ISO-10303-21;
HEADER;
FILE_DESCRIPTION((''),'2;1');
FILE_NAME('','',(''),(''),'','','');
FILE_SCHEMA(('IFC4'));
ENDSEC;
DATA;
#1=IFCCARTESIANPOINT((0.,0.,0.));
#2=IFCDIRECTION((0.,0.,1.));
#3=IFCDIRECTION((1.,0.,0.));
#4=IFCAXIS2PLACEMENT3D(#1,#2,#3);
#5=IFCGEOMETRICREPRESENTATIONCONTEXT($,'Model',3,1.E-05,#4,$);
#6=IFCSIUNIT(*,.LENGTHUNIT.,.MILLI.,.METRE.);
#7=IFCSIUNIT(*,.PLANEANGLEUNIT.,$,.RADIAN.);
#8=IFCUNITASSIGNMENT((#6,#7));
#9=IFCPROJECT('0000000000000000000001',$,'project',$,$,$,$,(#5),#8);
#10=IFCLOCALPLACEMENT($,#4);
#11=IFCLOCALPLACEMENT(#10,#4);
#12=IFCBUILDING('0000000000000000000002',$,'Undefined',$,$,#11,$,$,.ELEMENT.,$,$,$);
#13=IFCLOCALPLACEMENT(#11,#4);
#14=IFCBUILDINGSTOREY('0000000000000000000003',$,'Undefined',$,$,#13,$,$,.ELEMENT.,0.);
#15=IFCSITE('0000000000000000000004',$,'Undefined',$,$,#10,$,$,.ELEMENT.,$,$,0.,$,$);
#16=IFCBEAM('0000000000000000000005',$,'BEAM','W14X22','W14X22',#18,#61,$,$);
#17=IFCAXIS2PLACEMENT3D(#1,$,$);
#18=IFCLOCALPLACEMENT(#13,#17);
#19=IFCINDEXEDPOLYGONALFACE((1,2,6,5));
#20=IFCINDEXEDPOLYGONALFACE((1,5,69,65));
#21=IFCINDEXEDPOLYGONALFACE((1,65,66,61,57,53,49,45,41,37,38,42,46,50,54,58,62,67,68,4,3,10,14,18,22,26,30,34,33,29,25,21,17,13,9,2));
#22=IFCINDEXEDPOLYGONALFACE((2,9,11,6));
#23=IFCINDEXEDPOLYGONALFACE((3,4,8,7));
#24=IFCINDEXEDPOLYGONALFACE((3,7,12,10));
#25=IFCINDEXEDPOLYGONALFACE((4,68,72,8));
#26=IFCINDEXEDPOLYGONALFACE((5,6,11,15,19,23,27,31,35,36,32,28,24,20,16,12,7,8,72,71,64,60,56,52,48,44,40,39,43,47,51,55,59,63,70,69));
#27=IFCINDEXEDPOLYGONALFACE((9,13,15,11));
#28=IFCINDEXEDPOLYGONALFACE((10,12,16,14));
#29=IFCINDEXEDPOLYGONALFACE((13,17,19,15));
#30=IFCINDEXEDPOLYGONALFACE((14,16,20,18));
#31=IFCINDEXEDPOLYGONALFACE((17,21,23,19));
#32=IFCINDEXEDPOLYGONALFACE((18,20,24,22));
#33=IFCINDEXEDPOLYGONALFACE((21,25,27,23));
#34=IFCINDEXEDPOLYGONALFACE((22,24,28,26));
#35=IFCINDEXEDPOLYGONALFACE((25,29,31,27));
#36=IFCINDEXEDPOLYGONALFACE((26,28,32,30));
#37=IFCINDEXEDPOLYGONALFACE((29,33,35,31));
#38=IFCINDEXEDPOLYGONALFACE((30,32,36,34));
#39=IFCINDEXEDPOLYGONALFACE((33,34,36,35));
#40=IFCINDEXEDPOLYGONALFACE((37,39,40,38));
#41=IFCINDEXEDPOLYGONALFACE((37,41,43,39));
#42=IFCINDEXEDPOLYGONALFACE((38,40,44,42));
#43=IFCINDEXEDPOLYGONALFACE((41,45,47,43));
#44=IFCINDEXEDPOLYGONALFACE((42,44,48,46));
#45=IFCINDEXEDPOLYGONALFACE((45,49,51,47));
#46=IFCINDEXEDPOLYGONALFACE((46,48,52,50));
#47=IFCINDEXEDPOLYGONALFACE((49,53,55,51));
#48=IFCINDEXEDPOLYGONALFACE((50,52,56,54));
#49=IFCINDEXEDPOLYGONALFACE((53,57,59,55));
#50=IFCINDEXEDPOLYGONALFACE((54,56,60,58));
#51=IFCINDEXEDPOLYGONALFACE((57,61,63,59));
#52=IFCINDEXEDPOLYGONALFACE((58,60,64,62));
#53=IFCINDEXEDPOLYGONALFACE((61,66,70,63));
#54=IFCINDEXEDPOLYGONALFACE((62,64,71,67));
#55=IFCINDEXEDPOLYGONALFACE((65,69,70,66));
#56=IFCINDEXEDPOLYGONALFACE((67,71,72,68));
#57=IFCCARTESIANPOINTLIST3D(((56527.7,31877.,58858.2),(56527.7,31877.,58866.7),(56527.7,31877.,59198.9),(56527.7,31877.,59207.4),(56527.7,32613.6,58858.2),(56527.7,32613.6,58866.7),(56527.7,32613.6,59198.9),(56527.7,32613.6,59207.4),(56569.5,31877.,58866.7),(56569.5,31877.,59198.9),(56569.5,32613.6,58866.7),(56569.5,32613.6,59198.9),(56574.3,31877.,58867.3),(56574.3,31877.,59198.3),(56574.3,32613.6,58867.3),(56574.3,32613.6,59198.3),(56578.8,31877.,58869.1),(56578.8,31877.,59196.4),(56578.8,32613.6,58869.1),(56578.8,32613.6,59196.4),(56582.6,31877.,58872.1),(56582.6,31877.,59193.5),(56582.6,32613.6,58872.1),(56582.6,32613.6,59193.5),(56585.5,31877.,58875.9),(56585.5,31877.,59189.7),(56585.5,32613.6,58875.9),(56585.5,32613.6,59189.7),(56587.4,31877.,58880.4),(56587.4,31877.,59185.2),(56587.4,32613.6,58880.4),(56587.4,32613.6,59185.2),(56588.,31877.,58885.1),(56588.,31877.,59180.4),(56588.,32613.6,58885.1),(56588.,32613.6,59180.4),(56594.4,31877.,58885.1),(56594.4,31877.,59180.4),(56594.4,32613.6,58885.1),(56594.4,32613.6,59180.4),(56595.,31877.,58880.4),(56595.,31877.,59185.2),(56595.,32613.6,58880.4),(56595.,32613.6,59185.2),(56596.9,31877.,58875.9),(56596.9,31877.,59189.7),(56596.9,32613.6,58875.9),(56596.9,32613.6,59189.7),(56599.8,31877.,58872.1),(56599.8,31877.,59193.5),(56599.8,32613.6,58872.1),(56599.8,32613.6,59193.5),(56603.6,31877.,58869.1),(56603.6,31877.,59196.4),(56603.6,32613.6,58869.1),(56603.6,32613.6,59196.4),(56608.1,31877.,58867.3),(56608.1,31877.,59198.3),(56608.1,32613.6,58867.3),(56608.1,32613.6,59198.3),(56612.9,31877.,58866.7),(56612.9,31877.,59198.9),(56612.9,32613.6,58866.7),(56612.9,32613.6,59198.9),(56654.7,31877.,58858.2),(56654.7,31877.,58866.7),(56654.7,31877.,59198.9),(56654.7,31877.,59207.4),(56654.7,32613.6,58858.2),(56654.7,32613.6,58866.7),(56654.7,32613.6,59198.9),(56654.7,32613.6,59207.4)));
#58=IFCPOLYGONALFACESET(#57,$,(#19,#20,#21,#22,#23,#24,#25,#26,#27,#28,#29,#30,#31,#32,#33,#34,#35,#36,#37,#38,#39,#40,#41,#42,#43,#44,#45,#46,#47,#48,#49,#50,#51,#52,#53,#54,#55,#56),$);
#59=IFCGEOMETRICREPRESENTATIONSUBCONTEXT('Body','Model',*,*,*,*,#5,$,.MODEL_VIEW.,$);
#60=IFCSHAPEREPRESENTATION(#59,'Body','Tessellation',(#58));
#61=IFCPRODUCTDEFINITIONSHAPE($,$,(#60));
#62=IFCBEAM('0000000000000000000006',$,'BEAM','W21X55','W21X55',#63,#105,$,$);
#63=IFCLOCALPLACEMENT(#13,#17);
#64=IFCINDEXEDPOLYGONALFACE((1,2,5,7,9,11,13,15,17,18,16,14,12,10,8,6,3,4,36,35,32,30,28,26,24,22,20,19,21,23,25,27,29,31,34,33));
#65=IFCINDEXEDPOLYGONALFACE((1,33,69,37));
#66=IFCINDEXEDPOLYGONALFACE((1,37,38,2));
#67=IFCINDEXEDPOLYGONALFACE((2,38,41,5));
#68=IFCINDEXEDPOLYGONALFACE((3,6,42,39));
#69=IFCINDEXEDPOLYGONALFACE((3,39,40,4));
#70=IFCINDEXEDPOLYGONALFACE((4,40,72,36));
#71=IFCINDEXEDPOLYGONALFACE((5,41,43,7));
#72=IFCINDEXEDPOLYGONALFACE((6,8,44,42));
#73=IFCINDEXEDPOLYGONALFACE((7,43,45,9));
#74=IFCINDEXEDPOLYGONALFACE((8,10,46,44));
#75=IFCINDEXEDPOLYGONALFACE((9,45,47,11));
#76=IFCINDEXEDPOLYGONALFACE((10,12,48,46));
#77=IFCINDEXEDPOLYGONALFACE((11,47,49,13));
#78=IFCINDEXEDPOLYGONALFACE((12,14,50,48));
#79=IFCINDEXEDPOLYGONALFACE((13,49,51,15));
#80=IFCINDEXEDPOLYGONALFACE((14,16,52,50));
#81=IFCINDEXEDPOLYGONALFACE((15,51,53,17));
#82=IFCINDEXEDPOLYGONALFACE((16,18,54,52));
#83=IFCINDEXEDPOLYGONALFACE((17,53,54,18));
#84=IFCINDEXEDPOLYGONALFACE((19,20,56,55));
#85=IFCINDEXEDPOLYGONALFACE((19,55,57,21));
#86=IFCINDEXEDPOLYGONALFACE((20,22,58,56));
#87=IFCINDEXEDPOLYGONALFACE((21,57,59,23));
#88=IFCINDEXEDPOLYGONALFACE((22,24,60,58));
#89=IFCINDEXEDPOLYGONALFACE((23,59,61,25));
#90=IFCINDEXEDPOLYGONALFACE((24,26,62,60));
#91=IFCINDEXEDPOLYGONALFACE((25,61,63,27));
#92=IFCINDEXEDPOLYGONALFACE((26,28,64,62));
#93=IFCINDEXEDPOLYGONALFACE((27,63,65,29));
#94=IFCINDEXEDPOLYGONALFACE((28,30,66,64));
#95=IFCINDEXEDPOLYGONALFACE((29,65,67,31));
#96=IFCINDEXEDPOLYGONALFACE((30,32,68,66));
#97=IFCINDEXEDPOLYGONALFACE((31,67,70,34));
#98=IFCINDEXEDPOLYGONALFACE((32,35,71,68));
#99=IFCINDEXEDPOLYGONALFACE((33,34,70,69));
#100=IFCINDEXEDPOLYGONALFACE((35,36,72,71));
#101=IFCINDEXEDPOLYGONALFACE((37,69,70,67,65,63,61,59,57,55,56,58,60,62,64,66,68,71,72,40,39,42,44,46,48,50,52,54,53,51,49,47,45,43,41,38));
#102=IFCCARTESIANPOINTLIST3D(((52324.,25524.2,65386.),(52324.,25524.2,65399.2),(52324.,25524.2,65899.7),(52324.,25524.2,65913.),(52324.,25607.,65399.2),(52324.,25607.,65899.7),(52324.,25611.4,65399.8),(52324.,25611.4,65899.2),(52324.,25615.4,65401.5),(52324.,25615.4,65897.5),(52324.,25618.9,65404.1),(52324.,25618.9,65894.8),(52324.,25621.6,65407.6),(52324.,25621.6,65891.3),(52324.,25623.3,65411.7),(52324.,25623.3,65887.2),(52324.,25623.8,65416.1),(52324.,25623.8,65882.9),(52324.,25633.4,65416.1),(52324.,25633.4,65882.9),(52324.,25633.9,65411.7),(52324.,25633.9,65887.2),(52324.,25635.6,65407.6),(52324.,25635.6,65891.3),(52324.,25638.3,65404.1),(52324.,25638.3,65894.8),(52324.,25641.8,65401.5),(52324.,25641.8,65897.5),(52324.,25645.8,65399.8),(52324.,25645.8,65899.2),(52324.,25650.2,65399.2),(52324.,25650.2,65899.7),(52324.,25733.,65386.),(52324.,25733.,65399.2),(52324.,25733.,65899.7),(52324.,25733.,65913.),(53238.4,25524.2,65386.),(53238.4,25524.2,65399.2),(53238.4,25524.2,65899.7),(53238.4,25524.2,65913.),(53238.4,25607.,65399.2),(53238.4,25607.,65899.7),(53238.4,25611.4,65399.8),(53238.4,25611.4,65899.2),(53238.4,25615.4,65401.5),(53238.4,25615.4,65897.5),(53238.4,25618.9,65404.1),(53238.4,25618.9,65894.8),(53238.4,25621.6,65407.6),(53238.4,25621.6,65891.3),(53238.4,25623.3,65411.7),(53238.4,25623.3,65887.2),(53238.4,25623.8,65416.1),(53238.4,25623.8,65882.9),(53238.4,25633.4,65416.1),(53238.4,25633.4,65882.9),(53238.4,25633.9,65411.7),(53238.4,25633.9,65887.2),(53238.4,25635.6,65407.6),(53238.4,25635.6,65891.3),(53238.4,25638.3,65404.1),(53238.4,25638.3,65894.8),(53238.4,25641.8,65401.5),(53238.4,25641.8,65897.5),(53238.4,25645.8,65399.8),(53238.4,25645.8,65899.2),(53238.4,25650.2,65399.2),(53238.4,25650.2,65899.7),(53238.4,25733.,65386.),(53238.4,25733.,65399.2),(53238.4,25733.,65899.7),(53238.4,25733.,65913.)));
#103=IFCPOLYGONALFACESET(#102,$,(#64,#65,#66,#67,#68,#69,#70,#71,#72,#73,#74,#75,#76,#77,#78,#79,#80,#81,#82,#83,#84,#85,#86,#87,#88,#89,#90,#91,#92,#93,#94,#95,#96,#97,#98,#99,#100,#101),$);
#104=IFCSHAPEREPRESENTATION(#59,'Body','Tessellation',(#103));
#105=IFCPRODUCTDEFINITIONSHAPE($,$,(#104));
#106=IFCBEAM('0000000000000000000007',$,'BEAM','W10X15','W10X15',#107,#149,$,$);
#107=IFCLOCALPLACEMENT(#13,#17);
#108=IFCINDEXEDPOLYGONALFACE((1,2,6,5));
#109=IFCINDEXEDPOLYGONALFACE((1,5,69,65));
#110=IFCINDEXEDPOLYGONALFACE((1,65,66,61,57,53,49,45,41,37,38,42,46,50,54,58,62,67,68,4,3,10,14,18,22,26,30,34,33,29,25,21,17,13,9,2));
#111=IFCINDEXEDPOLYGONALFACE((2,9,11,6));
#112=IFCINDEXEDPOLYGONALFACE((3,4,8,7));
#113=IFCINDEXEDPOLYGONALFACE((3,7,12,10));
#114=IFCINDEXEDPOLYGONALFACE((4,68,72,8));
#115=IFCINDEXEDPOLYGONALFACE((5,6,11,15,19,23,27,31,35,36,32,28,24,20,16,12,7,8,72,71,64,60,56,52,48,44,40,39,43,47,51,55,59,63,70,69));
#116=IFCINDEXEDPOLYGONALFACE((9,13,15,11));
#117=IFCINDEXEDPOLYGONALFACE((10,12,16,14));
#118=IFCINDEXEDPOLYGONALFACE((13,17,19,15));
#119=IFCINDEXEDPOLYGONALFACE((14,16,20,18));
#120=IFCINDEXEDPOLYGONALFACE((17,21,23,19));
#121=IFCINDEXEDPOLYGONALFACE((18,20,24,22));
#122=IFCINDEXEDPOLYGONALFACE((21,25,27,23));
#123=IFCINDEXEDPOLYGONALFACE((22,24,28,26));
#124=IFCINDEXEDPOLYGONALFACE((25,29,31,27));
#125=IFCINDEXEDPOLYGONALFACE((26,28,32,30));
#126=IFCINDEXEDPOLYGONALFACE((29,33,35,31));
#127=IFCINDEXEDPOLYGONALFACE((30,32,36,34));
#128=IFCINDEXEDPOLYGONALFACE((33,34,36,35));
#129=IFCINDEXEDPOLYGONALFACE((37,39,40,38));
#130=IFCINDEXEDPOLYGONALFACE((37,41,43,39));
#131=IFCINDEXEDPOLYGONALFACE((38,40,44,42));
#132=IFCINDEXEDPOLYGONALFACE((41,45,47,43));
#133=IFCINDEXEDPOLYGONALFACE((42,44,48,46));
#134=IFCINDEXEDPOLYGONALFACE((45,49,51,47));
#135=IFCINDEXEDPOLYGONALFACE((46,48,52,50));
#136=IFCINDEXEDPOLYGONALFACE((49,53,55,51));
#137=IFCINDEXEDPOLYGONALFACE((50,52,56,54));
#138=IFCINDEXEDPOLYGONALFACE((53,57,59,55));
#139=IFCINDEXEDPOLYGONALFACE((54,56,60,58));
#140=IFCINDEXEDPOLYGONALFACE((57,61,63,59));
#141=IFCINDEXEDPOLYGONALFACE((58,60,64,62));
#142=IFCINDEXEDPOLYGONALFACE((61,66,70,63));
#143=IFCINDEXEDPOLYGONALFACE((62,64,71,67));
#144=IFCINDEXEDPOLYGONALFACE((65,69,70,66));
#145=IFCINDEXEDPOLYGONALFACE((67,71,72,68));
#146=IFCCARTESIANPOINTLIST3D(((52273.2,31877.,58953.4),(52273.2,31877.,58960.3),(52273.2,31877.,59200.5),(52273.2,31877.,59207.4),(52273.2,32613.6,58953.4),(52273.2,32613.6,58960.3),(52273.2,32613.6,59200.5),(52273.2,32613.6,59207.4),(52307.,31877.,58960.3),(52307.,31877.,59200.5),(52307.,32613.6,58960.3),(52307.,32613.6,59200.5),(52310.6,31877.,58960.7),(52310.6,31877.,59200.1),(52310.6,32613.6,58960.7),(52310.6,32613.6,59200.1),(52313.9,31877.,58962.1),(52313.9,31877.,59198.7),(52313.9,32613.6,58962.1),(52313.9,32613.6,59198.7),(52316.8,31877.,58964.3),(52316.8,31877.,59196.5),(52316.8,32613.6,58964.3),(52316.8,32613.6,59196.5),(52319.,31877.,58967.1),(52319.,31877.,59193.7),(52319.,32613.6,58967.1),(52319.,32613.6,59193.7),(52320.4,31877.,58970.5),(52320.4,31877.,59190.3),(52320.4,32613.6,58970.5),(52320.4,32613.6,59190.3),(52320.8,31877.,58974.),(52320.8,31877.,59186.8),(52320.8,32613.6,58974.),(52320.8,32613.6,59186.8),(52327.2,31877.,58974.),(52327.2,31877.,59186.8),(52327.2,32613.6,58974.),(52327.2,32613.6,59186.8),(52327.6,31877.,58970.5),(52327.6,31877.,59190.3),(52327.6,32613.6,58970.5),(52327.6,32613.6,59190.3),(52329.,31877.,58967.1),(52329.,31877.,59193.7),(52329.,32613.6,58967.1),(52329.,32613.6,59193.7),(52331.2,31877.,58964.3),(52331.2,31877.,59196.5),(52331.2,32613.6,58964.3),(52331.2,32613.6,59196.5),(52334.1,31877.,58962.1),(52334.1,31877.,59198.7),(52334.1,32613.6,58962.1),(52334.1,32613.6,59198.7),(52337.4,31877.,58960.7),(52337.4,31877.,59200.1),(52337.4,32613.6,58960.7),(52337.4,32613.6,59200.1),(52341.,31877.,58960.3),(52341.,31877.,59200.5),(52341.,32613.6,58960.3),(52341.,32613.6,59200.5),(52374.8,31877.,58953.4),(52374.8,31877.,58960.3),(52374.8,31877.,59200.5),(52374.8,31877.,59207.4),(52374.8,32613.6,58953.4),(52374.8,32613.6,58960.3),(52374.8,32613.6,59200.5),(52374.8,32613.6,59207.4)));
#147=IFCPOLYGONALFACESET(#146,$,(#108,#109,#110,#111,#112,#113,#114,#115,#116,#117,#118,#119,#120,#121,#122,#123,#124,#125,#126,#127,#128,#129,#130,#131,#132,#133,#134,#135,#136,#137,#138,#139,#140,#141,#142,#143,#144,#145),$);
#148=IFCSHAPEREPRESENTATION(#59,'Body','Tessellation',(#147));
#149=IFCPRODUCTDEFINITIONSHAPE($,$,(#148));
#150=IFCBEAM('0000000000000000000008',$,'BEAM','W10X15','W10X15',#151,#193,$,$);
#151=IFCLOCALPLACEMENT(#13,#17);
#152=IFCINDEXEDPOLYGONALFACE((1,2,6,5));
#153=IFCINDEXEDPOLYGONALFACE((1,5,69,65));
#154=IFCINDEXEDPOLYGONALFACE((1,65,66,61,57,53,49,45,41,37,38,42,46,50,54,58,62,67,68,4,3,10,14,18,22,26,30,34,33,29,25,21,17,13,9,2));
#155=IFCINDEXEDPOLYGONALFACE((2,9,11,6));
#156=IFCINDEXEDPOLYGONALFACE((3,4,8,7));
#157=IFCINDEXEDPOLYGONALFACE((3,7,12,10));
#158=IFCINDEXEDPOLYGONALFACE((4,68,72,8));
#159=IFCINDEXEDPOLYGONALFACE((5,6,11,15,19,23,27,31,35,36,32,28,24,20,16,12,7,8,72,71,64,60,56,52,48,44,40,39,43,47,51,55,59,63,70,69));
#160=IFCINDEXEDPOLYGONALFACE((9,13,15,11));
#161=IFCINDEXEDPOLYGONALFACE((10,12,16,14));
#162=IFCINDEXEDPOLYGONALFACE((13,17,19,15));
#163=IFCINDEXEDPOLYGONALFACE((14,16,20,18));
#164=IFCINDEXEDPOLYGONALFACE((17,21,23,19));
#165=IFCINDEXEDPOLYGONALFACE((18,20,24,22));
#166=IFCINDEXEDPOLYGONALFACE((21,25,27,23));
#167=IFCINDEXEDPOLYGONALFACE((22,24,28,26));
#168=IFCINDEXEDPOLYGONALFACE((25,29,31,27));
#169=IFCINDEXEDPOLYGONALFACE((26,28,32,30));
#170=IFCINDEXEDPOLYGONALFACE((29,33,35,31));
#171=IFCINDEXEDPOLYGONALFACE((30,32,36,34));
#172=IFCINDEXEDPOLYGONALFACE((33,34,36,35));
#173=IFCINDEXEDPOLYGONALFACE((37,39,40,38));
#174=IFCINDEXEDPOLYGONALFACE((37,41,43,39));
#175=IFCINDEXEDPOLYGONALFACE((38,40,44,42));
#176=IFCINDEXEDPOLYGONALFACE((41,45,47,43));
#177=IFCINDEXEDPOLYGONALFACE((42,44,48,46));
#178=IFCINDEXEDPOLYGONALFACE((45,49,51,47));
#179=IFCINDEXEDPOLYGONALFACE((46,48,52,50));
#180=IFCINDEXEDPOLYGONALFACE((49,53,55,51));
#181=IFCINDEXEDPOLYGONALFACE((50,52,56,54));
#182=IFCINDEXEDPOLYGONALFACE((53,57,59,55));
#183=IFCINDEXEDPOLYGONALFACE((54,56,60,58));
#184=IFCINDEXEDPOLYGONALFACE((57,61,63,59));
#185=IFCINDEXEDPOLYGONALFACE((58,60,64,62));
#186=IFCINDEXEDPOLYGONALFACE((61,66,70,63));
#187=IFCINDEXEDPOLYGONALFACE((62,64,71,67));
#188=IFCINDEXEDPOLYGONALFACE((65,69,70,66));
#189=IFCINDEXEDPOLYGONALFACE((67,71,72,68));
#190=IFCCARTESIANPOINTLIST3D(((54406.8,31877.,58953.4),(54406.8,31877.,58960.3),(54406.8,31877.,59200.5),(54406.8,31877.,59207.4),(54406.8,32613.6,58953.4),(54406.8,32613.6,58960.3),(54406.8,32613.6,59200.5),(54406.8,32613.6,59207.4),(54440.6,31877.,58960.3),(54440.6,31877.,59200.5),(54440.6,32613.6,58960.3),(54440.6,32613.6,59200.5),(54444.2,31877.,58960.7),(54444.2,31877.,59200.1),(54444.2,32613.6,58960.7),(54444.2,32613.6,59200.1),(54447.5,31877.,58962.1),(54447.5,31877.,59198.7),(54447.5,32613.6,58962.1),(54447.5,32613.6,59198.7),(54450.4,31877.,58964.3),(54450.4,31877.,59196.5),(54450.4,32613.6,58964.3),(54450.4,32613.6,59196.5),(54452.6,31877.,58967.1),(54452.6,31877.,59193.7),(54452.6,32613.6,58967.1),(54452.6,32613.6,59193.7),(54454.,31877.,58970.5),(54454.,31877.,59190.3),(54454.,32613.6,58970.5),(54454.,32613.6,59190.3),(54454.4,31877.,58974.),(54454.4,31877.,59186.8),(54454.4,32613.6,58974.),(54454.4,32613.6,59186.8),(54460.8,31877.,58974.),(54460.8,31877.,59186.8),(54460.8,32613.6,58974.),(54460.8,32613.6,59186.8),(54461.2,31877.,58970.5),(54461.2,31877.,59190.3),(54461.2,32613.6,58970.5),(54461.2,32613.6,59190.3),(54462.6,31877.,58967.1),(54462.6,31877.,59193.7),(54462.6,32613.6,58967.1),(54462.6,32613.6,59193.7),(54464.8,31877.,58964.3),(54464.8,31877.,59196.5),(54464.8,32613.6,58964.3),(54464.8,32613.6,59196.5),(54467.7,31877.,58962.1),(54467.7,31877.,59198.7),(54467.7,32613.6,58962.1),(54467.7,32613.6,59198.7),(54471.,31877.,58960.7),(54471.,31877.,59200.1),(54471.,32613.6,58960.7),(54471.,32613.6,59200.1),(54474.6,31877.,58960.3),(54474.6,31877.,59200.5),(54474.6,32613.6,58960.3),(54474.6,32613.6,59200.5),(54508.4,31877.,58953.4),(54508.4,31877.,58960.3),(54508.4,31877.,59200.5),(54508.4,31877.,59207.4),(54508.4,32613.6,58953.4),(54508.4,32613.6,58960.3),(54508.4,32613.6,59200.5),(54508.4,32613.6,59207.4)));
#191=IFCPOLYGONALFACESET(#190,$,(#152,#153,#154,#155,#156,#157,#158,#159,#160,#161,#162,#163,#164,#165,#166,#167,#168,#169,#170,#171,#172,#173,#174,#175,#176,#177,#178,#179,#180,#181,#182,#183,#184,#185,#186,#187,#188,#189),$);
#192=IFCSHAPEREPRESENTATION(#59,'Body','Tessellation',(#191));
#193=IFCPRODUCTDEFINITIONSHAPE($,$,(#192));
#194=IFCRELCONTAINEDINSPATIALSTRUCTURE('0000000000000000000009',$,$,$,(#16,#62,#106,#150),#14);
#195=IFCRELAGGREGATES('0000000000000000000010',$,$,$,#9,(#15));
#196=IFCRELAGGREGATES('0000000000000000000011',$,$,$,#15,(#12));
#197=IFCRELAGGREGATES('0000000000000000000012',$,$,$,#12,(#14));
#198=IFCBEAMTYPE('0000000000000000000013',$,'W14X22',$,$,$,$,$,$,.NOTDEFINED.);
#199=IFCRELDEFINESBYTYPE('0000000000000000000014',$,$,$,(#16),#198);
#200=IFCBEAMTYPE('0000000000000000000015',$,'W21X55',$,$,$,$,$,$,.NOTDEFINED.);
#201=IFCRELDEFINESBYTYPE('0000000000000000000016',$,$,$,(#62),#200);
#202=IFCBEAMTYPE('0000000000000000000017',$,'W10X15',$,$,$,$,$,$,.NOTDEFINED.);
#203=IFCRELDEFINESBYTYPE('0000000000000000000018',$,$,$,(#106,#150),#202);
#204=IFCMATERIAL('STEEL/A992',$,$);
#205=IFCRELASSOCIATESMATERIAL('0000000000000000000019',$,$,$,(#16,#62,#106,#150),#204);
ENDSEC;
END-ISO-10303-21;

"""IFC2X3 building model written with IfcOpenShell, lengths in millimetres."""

from ifc_helpers import new_model, si_unit, frame, origin_with_axes, origin_2d_with_axis, place, context, subcontext, project, spatial, i_section, extrude, material, type_object, element, save


model = new_model("IFC2X3")

# Units and contexts
model_context = context("Model", 3, precision=1e-05, world=origin_with_axes())
body_context = subcontext(model_context, "Body", "Model", "MODEL_VIEW")
ifc_project = project(units=[si_unit("LENGTHUNIT", "METRE", prefix="MILLI"), si_unit("PLANEANGLEUNIT", "RADIAN")], contexts=[model_context])

# Site, building, storey
site_placement = place(None, origin_with_axes())
site = spatial("IfcSite", under=ifc_project, at=site_placement, Name="Undefined", CompositionType="ELEMENT", RefElevation=0.0)
building_placement = place(site_placement, origin_with_axes())
building = spatial("IfcBuilding", under=site, at=building_placement, Name="Undefined", CompositionType="ELEMENT")
storey_placement = place(building_placement, origin_with_axes())
storey = spatial("IfcBuildingStorey", under=building, at=storey_placement, Name="Undefined", CompositionType="ELEMENT", Elevation=0.0)

# Beams
ifc_material_1 = material(Name="STEEL/A992")
beam_type_1 = type_object("IfcBeamType", Name="W14X22", PredefinedType="NOTDEFINED")
beam_1_placement = place(storey_placement, frame((56591.2, 31877.0, 59032.8), z_axis=(0.0, 0.0, 1.0), x_axis=(0.0, 1.0, 0.0)))
element("IfcBeam", 1, at=beam_1_placement, inside=storey, type_object=beam_type_1, material=ifc_material_1, Name="BEAM", Description="W14X22", ObjectType="W14X22", context=body_context, shape_type="SweptSolid", body=[
    extrude(i_section(OverallWidth=127.0, OverallDepth=349.2, WebThickness=6.3, FlangeThickness=8.5, FilletRadius=18.5, at=origin_2d_with_axis()), frame((736.6, 0.0, 0.0), z_axis=(-1.0, 0.0, 0.0), x_axis=(0.0, -1.0, 0.0)), (0.0, 0.0, 1.0), 736.6),
])
beam_type_2 = type_object("IfcBeamType", Name="W21X55", PredefinedType="NOTDEFINED")
beam_2_placement = place(storey_placement, frame((52324.0, 25628.6, 65649.5), z_axis=(0.0, 0.0, 1.0), x_axis=(1.0, 0.0, 0.0)))
element("IfcBeam", 2, at=beam_2_placement, inside=storey, type_object=beam_type_2, material=ifc_material_1, Name="BEAM", Description="W21X55", ObjectType="W21X55", context=body_context, shape_type="SweptSolid", body=[
    extrude(i_section(OverallWidth=208.8, OverallDepth=527.0, WebThickness=9.5, FlangeThickness=13.3, FilletRadius=16.9, at=origin_2d_with_axis()), frame((914.4, 0.0, 0.0), z_axis=(-1.0, 0.0, 0.0), x_axis=(0.0, -1.0, 0.0)), (0.0, 0.0, 1.0), 914.4),
])
beam_type_3 = type_object("IfcBeamType", Name="W10X15", PredefinedType="NOTDEFINED")
for number, where, z_axis, x_axis, name in (
    (3, (52324.0, 31877.0, 59080.4), (0.0, 0.0, 1.0), (0.0, 1.0, 0.0), "BEAM"),
    (4, (54457.6, 31877.0, 59080.4), (0.0, 0.0, 1.0), (0.0, 1.0, 0.0), "BEAM"),
):
    element("IfcBeam", number, at=place(storey_placement, frame(where, z_axis=z_axis, x_axis=x_axis)), inside=storey, type_object=beam_type_3, material=ifc_material_1, Name=name, Description="W10X15", ObjectType="W10X15", context=body_context, shape_type="SweptSolid", body=[
        extrude(i_section(OverallWidth=101.6, OverallDepth=254.0, WebThickness=6.3, FlangeThickness=6.9, FilletRadius=13.8, at=origin_2d_with_axis()), frame((736.6, 0.0, 0.0), z_axis=(-1.0, 0.0, 0.0), x_axis=(0.0, -1.0, 0.0)), (0.0, 0.0, 1.0), 736.6),
    ])

save(model, "model.ifc")
